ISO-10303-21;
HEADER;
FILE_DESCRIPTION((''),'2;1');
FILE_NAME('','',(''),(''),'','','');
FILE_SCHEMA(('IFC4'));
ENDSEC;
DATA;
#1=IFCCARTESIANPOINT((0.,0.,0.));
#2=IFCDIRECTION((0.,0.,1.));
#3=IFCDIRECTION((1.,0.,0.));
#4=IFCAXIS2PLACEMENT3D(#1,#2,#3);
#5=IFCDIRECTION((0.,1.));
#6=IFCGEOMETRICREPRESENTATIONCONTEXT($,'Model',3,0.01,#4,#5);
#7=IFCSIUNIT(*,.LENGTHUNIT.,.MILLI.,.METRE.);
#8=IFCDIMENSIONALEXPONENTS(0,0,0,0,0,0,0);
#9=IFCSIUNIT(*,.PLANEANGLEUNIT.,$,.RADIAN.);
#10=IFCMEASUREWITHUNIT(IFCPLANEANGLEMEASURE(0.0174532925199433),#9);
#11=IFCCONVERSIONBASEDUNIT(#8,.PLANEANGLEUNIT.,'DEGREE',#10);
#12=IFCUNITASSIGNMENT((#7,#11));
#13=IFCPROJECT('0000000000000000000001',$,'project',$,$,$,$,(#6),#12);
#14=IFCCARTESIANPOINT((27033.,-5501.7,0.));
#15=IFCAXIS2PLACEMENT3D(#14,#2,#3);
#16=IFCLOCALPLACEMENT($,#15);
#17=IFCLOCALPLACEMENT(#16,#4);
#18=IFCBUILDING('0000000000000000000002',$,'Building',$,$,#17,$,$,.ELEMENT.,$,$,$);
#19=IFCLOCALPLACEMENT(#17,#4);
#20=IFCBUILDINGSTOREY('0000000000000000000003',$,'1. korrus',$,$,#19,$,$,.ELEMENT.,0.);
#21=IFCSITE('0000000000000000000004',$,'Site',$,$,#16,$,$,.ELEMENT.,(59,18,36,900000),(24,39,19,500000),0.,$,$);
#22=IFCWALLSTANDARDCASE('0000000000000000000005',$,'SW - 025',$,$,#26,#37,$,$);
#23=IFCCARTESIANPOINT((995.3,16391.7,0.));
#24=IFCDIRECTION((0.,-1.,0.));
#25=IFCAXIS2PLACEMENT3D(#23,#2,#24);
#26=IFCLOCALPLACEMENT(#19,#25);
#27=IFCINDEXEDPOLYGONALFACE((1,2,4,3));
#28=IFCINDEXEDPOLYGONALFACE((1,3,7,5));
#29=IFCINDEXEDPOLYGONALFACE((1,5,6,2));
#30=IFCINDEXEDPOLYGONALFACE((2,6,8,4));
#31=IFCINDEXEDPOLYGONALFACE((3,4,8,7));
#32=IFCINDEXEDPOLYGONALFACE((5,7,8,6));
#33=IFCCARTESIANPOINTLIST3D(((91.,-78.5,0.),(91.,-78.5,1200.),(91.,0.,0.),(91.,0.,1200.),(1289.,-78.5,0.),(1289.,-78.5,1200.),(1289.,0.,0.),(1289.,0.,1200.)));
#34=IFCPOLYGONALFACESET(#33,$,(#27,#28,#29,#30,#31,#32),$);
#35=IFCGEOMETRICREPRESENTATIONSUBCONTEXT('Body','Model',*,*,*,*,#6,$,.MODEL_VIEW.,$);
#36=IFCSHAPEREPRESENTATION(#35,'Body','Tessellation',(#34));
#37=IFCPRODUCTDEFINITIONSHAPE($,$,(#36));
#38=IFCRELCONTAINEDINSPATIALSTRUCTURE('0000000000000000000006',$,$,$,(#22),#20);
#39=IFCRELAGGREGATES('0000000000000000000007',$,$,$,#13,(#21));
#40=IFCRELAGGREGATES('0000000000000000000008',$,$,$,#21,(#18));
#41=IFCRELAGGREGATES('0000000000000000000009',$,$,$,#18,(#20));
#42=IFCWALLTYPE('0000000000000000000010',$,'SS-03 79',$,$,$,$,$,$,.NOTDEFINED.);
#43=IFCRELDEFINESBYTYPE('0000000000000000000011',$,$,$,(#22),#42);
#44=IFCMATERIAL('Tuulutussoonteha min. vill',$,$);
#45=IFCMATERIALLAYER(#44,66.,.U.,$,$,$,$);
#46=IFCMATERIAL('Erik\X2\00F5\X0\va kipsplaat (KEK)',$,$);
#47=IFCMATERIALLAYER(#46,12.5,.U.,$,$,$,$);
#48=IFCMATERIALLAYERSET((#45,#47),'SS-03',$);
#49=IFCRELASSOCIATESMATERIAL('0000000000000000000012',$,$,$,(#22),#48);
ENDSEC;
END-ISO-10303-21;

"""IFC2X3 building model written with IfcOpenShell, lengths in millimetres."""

from ifc_helpers import new_model, entity, si_unit, converted_unit, direction, frame, origin_with_axes, place, context, subcontext, project, spatial, polyline, outline, extrude, material, layer, layer_set, layer_usage, type_object, element, save


model = new_model("IFC2X3")

# Units and contexts
model_context = context("Model", 3, precision=0.01, world=origin_with_axes(), true_north=direction((0.0, 1.0)))
body_context = subcontext(model_context, "Body", "Model", "MODEL_VIEW")
ifc_project = project(units=[si_unit("LENGTHUNIT", "METRE", prefix="MILLI"), converted_unit("PLANEANGLEUNIT", "DEGREE", entity("IfcPlaneAngleMeasure", 0.0174532925199433), si_unit("PLANEANGLEUNIT", "RADIAN"), dimensions=[0, 0, 0, 0, 0, 0, 0])], contexts=[model_context])

# Site, building, storey
site_placement = place(None, frame((27033.0, -5501.7, 0.0), z_axis=(0.0, 0.0, 1.0), x_axis=(1.0, 0.0, 0.0)))
site = spatial("IfcSite", under=ifc_project, at=site_placement, Name="Site", CompositionType="ELEMENT", RefLatitude=(59, 18, 36, 900000), RefLongitude=(24, 39, 19, 500000), RefElevation=0.0)
building_placement = place(site_placement, origin_with_axes())
building = spatial("IfcBuilding", under=site, at=building_placement, Name="Building", CompositionType="ELEMENT")
storey_placement = place(building_placement, origin_with_axes())
storey = spatial("IfcBuildingStorey", under=building, at=storey_placement, Name="1. korrus", CompositionType="ELEMENT", Elevation=0.0)

# Shared definitions
ifc_material_1 = material(Name="Erikõva kipsplaat (KEK)")
ifc_material_2 = material(Name="Tuulutussoonteha min. vill")

# Wall
ifc_layer_1 = layer(ifc_material_2, 66.0, ventilated="UNKNOWN")
ifc_layer_2 = layer(ifc_material_1, 12.5, ventilated="UNKNOWN")
ifc_layer_set_1 = layer_set([ifc_layer_1, ifc_layer_2], Name="SS-03")
wall_type_1 = type_object("IfcWallType", Name="SS-03 79", PredefinedType="NOTDEFINED")
ifc_layer_usage_1 = layer_usage(ifc_layer_set_1, "AXIS2", "POSITIVE", -78.5)
wall_1_placement = place(storey_placement, frame((995.3, 16391.7, 0.0), z_axis=(0.0, 0.0, 1.0), x_axis=(0.0, -1.0, 0.0)))
element("IfcWallStandardCase", 1, at=wall_1_placement, inside=storey, type_object=wall_type_1, material=ifc_layer_usage_1, Name="SW - 025", context=body_context, shape_type="SweptSolid", body=[
    extrude(outline(polyline([(91.0, -78.5), (1289.0, -78.5), (1289.0, 0.0), (91.0, 0.0), (91.0, -78.5)])), origin_with_axes(), (0.0, 0.0, 1.0), 1200.0),
])

save(model, "model.ifc")
